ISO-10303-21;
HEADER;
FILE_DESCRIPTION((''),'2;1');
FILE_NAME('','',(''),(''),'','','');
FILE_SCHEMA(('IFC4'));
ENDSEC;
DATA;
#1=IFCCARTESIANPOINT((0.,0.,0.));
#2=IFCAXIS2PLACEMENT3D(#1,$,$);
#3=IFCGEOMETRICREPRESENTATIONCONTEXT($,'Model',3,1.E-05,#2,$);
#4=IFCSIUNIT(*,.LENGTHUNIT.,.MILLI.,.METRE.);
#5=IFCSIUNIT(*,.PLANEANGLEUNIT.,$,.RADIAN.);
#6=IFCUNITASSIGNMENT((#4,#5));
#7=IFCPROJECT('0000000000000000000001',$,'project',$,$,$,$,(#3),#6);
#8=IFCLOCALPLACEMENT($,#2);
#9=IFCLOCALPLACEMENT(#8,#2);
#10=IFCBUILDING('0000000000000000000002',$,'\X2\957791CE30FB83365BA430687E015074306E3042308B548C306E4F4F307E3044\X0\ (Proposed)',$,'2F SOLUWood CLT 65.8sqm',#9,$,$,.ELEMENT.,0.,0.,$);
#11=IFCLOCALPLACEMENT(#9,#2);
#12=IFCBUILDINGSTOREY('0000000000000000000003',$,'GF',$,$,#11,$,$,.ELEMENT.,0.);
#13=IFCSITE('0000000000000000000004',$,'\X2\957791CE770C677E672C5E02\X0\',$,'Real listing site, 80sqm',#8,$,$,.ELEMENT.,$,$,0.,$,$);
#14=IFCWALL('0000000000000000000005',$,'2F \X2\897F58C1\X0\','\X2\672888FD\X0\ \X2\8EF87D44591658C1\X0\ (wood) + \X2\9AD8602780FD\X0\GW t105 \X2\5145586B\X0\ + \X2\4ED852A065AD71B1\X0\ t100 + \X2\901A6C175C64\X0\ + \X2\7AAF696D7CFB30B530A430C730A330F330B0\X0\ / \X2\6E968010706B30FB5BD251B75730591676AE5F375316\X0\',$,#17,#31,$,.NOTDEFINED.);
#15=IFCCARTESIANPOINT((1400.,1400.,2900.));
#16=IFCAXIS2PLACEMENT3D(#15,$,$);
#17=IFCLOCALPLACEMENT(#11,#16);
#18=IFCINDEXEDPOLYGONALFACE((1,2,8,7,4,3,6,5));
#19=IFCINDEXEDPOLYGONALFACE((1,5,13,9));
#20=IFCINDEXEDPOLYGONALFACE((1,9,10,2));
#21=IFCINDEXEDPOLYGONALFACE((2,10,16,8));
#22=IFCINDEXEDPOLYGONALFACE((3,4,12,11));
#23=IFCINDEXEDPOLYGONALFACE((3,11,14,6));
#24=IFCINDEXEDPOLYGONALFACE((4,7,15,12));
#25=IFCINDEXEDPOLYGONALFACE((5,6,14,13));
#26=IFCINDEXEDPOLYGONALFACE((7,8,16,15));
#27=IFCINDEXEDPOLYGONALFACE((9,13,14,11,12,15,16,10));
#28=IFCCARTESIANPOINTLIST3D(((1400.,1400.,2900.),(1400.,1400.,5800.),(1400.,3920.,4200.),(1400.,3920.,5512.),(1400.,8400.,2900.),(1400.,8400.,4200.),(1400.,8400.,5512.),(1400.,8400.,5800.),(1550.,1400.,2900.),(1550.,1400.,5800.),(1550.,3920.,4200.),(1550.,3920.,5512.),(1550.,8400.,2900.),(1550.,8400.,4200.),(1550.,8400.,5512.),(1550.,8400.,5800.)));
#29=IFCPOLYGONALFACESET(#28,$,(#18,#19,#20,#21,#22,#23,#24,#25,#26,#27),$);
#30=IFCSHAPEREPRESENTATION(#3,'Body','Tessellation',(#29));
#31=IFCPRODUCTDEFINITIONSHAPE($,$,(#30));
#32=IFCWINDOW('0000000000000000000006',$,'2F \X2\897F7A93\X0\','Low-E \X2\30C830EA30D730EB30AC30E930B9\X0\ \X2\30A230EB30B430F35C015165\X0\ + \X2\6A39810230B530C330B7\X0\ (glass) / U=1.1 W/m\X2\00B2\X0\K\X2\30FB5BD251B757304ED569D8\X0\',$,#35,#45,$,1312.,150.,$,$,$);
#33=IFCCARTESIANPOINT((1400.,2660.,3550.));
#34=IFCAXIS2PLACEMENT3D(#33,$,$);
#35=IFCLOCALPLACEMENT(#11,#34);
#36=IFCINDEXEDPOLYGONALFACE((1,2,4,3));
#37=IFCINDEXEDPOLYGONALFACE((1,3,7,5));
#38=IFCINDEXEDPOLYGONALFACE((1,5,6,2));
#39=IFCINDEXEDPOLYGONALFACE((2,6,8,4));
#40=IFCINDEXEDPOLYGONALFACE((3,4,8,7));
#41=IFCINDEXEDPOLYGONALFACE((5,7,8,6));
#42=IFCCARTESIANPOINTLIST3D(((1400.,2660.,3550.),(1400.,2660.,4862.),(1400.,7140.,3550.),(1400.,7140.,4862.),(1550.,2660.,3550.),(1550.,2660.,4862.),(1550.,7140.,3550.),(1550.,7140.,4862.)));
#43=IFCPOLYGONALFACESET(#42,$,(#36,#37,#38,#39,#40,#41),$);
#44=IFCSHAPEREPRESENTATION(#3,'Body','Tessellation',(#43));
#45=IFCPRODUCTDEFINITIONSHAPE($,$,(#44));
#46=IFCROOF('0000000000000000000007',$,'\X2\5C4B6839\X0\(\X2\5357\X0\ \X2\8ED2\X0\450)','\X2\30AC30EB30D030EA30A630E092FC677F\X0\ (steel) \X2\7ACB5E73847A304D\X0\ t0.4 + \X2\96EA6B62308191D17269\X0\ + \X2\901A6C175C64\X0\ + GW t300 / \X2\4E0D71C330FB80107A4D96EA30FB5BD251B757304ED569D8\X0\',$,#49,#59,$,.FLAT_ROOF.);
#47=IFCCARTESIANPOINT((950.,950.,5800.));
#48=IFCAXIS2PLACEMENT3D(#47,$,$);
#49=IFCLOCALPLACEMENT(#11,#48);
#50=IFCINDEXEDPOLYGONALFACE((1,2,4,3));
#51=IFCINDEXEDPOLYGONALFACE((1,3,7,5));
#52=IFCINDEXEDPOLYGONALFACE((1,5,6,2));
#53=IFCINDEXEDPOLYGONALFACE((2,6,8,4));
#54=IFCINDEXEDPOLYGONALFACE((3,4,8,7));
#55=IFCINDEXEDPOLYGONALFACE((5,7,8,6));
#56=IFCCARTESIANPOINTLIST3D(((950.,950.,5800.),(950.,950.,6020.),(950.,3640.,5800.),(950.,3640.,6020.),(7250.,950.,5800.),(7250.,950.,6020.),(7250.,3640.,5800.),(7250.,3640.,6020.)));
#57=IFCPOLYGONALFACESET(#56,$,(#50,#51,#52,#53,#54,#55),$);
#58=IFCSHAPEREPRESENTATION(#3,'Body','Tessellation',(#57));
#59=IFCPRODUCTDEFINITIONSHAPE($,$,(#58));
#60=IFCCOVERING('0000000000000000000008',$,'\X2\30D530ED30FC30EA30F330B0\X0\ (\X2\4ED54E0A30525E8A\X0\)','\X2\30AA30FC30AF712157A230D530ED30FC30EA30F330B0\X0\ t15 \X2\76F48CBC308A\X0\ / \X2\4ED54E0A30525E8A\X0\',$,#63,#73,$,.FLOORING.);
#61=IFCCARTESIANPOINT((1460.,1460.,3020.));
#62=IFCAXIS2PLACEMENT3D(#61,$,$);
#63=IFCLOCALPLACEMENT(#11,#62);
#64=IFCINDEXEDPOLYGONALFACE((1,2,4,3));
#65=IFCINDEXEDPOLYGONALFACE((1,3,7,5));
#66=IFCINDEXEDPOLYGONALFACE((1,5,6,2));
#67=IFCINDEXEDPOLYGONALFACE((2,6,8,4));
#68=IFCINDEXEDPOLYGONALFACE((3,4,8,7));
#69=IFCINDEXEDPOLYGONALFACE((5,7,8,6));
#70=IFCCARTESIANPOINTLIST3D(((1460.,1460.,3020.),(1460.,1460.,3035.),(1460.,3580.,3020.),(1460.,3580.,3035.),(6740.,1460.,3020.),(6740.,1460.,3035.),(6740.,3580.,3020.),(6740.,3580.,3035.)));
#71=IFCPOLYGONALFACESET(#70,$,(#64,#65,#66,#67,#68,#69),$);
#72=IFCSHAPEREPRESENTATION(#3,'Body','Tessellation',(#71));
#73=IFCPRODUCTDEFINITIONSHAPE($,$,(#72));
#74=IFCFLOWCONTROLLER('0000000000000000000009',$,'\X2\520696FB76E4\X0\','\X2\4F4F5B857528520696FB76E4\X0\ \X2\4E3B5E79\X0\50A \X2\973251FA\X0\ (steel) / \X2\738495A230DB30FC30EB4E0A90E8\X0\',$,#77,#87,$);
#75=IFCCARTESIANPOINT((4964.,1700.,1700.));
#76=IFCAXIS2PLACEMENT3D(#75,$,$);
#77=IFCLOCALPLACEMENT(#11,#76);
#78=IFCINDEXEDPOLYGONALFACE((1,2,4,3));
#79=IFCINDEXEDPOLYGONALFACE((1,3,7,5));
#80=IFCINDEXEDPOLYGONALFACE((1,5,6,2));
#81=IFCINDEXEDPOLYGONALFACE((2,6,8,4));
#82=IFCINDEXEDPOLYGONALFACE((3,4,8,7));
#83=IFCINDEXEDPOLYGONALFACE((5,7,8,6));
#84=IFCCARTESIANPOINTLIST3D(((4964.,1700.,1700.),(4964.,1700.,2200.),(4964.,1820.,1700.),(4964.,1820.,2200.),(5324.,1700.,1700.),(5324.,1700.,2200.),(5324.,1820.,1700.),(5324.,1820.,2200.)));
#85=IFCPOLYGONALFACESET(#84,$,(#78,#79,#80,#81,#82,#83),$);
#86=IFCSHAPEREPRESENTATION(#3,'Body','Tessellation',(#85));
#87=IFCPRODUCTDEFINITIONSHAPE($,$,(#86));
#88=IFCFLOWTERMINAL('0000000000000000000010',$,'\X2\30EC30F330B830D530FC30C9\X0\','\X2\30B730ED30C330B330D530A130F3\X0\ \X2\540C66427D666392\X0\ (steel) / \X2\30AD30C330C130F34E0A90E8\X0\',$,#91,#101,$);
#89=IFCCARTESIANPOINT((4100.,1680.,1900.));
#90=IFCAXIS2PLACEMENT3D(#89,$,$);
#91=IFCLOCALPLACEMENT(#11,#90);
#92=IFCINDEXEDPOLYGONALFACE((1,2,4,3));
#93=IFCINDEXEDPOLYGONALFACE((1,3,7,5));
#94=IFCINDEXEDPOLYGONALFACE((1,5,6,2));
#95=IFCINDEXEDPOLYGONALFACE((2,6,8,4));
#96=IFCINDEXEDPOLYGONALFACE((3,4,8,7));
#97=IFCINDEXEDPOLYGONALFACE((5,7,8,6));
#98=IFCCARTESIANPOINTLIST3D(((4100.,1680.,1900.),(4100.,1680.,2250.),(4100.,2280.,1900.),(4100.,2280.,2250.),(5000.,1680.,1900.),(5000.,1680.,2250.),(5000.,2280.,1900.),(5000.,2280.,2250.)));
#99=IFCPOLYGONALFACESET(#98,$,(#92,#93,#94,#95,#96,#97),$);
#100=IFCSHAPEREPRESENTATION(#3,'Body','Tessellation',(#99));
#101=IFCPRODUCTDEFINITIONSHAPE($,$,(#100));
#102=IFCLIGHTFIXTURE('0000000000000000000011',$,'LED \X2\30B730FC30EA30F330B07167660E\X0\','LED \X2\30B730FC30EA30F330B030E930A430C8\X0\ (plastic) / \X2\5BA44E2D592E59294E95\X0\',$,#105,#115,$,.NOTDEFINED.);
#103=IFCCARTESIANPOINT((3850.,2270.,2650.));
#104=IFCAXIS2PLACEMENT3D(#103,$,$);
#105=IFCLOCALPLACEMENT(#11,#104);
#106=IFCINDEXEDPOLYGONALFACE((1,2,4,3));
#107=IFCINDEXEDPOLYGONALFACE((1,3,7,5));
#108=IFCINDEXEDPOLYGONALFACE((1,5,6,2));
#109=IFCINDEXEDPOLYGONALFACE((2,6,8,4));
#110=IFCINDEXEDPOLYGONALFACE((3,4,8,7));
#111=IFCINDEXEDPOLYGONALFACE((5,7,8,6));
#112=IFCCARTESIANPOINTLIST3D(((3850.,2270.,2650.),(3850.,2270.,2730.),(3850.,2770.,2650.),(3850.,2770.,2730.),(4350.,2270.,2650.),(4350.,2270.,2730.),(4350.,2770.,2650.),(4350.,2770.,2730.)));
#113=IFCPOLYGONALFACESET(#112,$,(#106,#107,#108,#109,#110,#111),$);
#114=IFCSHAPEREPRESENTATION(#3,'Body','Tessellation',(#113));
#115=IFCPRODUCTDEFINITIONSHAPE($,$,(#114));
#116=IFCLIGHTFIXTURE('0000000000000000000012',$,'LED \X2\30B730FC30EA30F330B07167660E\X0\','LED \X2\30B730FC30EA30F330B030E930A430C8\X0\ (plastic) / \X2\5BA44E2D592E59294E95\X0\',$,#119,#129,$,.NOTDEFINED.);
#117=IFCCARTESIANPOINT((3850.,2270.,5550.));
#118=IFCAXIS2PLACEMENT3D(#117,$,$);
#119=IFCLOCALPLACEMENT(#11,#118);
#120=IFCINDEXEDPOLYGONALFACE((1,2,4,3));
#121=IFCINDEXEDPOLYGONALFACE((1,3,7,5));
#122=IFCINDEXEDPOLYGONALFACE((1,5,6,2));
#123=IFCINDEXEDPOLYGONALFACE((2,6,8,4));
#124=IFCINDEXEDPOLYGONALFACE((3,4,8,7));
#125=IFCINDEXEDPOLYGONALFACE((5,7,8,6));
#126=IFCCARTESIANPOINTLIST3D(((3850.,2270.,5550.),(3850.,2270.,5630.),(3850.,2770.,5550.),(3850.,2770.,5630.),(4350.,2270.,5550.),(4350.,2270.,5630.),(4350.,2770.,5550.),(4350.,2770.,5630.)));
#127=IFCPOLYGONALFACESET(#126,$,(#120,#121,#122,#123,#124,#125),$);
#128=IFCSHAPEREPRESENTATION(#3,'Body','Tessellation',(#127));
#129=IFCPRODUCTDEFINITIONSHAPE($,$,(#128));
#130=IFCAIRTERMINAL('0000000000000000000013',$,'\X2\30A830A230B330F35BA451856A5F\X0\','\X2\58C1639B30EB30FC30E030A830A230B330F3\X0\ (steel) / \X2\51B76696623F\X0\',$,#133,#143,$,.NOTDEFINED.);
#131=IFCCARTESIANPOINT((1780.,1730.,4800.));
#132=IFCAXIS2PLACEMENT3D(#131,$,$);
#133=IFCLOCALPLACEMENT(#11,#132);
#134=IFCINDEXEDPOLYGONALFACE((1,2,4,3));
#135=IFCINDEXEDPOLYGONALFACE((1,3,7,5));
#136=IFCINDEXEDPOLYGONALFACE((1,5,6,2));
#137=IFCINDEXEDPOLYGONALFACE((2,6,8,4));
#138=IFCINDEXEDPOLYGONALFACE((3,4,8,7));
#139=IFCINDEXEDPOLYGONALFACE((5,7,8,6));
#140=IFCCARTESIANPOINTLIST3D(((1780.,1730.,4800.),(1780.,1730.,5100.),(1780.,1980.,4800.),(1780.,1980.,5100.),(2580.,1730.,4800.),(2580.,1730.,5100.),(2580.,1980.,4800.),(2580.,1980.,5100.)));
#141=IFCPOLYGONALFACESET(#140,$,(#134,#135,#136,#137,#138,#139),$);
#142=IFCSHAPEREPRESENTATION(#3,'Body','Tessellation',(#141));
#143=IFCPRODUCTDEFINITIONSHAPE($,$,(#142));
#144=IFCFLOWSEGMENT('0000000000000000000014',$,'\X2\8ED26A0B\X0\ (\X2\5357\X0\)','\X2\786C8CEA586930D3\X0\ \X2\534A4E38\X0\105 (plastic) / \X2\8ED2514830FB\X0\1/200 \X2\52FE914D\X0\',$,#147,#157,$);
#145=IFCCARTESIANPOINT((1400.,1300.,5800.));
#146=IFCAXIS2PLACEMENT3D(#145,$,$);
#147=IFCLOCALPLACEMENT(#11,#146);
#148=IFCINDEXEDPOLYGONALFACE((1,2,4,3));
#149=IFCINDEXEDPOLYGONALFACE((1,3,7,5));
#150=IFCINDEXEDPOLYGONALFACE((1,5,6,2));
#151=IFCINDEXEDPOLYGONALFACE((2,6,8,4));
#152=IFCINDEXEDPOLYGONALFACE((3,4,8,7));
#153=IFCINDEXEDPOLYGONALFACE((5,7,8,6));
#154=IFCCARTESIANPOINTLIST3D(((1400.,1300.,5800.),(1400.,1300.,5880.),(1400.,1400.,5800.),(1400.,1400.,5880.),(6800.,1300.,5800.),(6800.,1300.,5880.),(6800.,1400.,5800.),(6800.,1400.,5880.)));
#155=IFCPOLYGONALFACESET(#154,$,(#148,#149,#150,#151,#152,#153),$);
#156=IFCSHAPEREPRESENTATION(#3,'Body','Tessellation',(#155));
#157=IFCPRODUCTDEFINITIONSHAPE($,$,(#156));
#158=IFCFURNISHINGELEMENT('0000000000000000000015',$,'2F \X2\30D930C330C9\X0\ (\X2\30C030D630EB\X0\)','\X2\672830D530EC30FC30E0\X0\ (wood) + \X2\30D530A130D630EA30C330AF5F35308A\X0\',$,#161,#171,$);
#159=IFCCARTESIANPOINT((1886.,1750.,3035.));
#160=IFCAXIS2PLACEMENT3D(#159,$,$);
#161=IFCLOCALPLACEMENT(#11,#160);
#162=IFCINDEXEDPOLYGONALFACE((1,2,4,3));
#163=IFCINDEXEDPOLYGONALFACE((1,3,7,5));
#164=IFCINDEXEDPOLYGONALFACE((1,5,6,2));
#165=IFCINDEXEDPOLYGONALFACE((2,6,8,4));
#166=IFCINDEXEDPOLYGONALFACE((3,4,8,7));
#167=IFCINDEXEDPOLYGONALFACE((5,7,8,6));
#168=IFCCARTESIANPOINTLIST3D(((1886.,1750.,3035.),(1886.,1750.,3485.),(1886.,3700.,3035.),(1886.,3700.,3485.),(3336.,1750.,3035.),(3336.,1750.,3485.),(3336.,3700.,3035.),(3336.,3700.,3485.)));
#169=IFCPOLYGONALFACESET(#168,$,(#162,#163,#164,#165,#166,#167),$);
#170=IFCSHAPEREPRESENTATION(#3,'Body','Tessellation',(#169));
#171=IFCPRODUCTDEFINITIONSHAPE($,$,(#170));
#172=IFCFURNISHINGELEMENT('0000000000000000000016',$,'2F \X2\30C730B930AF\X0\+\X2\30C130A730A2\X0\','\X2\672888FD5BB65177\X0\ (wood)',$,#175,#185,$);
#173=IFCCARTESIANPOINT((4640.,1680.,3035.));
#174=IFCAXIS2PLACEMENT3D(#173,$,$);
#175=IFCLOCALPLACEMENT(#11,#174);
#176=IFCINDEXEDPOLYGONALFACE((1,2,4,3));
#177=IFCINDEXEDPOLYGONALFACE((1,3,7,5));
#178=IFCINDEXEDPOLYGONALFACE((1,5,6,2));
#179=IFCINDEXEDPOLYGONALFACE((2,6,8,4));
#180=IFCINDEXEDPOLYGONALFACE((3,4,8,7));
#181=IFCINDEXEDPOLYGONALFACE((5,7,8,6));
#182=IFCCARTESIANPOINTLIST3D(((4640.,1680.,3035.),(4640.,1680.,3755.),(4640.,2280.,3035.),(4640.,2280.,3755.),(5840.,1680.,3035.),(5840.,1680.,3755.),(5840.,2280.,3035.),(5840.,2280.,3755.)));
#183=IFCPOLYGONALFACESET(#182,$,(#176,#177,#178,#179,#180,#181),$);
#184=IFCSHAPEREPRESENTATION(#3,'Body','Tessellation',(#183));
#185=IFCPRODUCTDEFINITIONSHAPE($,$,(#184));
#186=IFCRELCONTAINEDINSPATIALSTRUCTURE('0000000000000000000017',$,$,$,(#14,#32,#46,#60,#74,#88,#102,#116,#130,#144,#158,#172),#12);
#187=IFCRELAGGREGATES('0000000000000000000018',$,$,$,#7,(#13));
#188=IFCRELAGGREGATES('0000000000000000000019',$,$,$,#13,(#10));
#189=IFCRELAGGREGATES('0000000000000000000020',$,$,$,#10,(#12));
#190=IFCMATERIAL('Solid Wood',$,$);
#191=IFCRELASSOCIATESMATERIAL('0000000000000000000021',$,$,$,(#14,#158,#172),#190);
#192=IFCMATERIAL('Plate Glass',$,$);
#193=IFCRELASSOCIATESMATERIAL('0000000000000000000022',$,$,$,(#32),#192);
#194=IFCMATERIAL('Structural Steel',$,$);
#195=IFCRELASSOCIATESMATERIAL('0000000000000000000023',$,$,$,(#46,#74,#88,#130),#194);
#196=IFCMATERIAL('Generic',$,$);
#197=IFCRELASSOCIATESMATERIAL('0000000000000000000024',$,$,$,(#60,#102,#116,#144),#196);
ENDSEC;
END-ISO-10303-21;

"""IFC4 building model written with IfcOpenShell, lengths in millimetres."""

from ifc_helpers import new_model, si_unit, frame, frame_2d, origin, place, context, project, spatial, rectangle, extrude, material, element, fill, save


model = new_model("IFC4")

# Units and contexts
model_context = context("Model", 3, precision=1e-05, world=origin())
ifc_project = project(units=[si_unit("LENGTHUNIT", "METRE", prefix="MILLI"), si_unit("PLANEANGLEUNIT", "RADIAN")], contexts=[model_context])

# Site, building, storey
site_placement = place(None, origin())
site = spatial("IfcSite", under=ifc_project, at=site_placement, Name="長野県松本市", ObjectType="Real listing site, 80sqm", CompositionType="ELEMENT", RefElevation=0.0)
building_placement = place(site_placement, origin())
building = spatial("IfcBuilding", under=site, at=building_placement, Name="長野・茶室と縁側のある和の住まい (Proposed)", ObjectType="2F SOLUWood CLT 65.8sqm", CompositionType="ELEMENT", ElevationOfRefHeight=0.0, ElevationOfTerrain=0.0)
storey_placement = place(building_placement, origin())
storey = spatial("IfcBuildingStorey", under=building, at=storey_placement, Name="GF", CompositionType="ELEMENT", Elevation=0.0)

# Shared definitions
ifc_material_1 = material(Name="Solid Wood")

# Wall, opening, window
ifc_material_2 = material(Name="Plate Glass")
wall_1_placement = place(storey_placement, frame((1400.0, 1400.0, 2900.0)))
wall_1 = element("IfcWall", 1, at=wall_1_placement, inside=storey, material=ifc_material_1, Name="2F 西壁", Description="木製 軸組外壁 (wood) + 高性能GW t105 充填 + 付加断熱 t100 + 通気層 + 窯業系サイディング / 準耐火・寒冷地外皮強化", PredefinedType="NOTDEFINED", context=model_context, shape_type="SweptSolid", body=[
    extrude(rectangle(XDim=150.0, YDim=7000.0, at=frame_2d((75.0, 3500.0))), frame((1400.0, 1400.0, 2900.0)), (0.0, 0.0, 1.0), 2900.0),
])
opening_1_placement = place(storey_placement, frame((1400.0, 2660.0, 3550.0)))
opening_1 = element("IfcOpeningElement", 2, at=opening_1_placement, cuts=wall_1, PredefinedType="NOTDEFINED", context=model_context, shape_type="SweptSolid", body=[
    extrude(rectangle(XDim=150.0, YDim=4480.0, at=frame_2d((75.0, 2240.0))), frame((1400.0, 2660.0, 3550.0)), (0.0, 0.0, 1.0), 1312.0),
])
window_1_placement = place(storey_placement, frame((1400.0, 2660.0, 3550.0)))
window_1 = element("IfcWindow", 3, at=window_1_placement, inside=storey, material=ifc_material_2, Name="2F 西窓", Description="Low-E トリプルガラス アルゴン封入 + 樹脂サッシ (glass) / U=1.1 W/m²K・寒冷地仕様", OverallHeight=1312.0, OverallWidth=150.0, context=model_context, shape_type="SweptSolid", body=[
    extrude(rectangle(XDim=150.0, YDim=4480.0, at=frame_2d((75.0, 2240.0))), frame((1400.0, 2660.0, 3550.0)), (0.0, 0.0, 1.0), 1312.0),
])
fill(opening_1, window_1)

# Roof
ifc_material_3 = material(Name="Structural Steel")
for number, where, name in (
    (4, (950.0, 950.0, 5800.0), "屋根(南 軒450)"),
):
    element("IfcRoof", number, at=place(storey_placement, frame(where)), inside=storey, material=ifc_material_3, Name=name, Description="ガルバリウム鋼板 (steel) 立平葺き t0.4 + 雪止め金物 + 通気層 + GW t300 / 不燃・耐積雪・寒冷地仕様", PredefinedType="FLAT_ROOF", context=model_context, shape_type="SweptSolid", body=[
        extrude(rectangle(XDim=6300.0, YDim=2690.0, at=frame_2d((3150.0, 1345.0))), frame((950.0, 950.0, 5800.0)), (0.0, 0.0, 1.0), 220.0),
    ])

# Covering
ifc_material_4 = material(Name="Generic")
covering_placement = place(storey_placement, frame((1460.0, 1460.0, 3020.0)))
element("IfcCovering", 5, at=covering_placement, inside=storey, material=ifc_material_4, Name="フローリング (仕上げ床)", Description="オーク無垢フローリング t15 直貼り / 仕上げ床", PredefinedType="FLOORING", context=model_context, shape_type="SweptSolid", body=[
    extrude(rectangle(XDim=5280.0, YDim=2120.0, at=frame_2d((2640.0, 1060.0))), frame((1460.0, 1460.0, 3020.0)), (0.0, 0.0, 1.0), 15.0),
])

# Flow controller
flow_controller_placement = place(storey_placement, frame((4964.0, 1700.0, 1700.0)))
element("IfcFlowController", 6, at=flow_controller_placement, inside=storey, material=ifc_material_3, Name="分電盤", Description="住宅用分電盤 主幹50A 露出 (steel) / 玄関ホール上部", context=model_context, shape_type="SweptSolid", body=[
    extrude(rectangle(XDim=360.0, YDim=120.0, at=frame_2d((180.0, 60.0))), frame((4964.0, 1700.0, 1700.0)), (0.0, 0.0, 1.0), 500.0),
])

# Flow terminal
flow_terminal_placement = place(storey_placement, frame((4100.0, 1680.0, 1900.0)))
element("IfcFlowTerminal", 7, at=flow_terminal_placement, inside=storey, material=ifc_material_3, Name="レンジフード", Description="シロッコファン 同時給排 (steel) / キッチン上部", context=model_context, shape_type="SweptSolid", body=[
    extrude(rectangle(XDim=900.0, YDim=600.0, at=frame_2d((450.0, 300.0))), frame((4100.0, 1680.0, 1900.0)), (0.0, 0.0, 1.0), 350.0),
])

# Light fixtures
light_fixture_1_placement = place(storey_placement, frame((3850.0, 2270.0, 2650.0)))
element("IfcLightFixture", 8, at=light_fixture_1_placement, inside=storey, material=ifc_material_4, Name="LED シーリング照明", Description="LED シーリングライト (plastic) / 室中央天井", PredefinedType="NOTDEFINED", context=model_context, shape_type="SweptSolid", body=[
    extrude(rectangle(XDim=500.0, YDim=500.0, at=frame_2d((250.0, 250.0))), frame((3850.0, 2270.0, 2650.0)), (0.0, 0.0, 1.0), 80.0),
])
light_fixture_2_placement = place(storey_placement, frame((3850.0, 2270.0, 5550.0)))
element("IfcLightFixture", 9, at=light_fixture_2_placement, inside=storey, material=ifc_material_4, Name="LED シーリング照明", Description="LED シーリングライト (plastic) / 室中央天井", PredefinedType="NOTDEFINED", context=model_context, shape_type="SweptSolid", body=[
    extrude(rectangle(XDim=500.0, YDim=500.0, at=frame_2d((250.0, 250.0))), frame((3850.0, 2270.0, 5550.0)), (0.0, 0.0, 1.0), 80.0),
])

# Air terminal
air_terminal_placement = place(storey_placement, frame((1780.0, 1730.0, 4800.0)))
element("IfcAirTerminal", 10, at=air_terminal_placement, inside=storey, material=ifc_material_3, Name="エアコン室内機", Description="壁掛ルームエアコン (steel) / 冷暖房", PredefinedType="NOTDEFINED", context=model_context, shape_type="SweptSolid", body=[
    extrude(rectangle(XDim=800.0, YDim=250.0, at=frame_2d((400.0, 125.0))), frame((1780.0, 1730.0, 4800.0)), (0.0, 0.0, 1.0), 300.0),
])

# Flow segment
flow_segment_placement = place(storey_placement, frame((1400.0, 1300.0, 5800.0)))
element("IfcFlowSegment", 11, at=flow_segment_placement, inside=storey, material=ifc_material_4, Name="軒樋 (南)", Description="硬質塩ビ 半丸105 (plastic) / 軒先・1/200 勾配", context=model_context, shape_type="SweptSolid", body=[
    extrude(rectangle(XDim=5400.0, YDim=100.0, at=frame_2d((2700.0, 50.0))), frame((1400.0, 1300.0, 5800.0)), (0.0, 0.0, 1.0), 80.0),
])

# Furnishing elements
furnishing_1_placement = place(storey_placement, frame((1886.0, 1750.0, 3035.0)))
element("IfcFurnishingElement", 12, at=furnishing_1_placement, inside=storey, material=ifc_material_1, Name="2F ベッド (ダブル)", Description="木フレーム (wood) + ファブリック張り", context=model_context, shape_type="SweptSolid", body=[
    extrude(rectangle(XDim=1450.0, YDim=1950.0, at=frame_2d((725.0, 975.0))), frame((1886.0, 1750.0, 3035.0)), (0.0, 0.0, 1.0), 450.0),
])
furnishing_2_placement = place(storey_placement, frame((4640.0, 1680.0, 3035.0)))
element("IfcFurnishingElement", 13, at=furnishing_2_placement, inside=storey, material=ifc_material_1, Name="2F デスク+チェア", Description="木製家具 (wood)", context=model_context, shape_type="SweptSolid", body=[
    extrude(rectangle(XDim=1200.0, YDim=600.0, at=frame_2d((600.0, 300.0))), frame((4640.0, 1680.0, 3035.0)), (0.0, 0.0, 1.0), 720.0),
])

save(model, "model.ifc")
